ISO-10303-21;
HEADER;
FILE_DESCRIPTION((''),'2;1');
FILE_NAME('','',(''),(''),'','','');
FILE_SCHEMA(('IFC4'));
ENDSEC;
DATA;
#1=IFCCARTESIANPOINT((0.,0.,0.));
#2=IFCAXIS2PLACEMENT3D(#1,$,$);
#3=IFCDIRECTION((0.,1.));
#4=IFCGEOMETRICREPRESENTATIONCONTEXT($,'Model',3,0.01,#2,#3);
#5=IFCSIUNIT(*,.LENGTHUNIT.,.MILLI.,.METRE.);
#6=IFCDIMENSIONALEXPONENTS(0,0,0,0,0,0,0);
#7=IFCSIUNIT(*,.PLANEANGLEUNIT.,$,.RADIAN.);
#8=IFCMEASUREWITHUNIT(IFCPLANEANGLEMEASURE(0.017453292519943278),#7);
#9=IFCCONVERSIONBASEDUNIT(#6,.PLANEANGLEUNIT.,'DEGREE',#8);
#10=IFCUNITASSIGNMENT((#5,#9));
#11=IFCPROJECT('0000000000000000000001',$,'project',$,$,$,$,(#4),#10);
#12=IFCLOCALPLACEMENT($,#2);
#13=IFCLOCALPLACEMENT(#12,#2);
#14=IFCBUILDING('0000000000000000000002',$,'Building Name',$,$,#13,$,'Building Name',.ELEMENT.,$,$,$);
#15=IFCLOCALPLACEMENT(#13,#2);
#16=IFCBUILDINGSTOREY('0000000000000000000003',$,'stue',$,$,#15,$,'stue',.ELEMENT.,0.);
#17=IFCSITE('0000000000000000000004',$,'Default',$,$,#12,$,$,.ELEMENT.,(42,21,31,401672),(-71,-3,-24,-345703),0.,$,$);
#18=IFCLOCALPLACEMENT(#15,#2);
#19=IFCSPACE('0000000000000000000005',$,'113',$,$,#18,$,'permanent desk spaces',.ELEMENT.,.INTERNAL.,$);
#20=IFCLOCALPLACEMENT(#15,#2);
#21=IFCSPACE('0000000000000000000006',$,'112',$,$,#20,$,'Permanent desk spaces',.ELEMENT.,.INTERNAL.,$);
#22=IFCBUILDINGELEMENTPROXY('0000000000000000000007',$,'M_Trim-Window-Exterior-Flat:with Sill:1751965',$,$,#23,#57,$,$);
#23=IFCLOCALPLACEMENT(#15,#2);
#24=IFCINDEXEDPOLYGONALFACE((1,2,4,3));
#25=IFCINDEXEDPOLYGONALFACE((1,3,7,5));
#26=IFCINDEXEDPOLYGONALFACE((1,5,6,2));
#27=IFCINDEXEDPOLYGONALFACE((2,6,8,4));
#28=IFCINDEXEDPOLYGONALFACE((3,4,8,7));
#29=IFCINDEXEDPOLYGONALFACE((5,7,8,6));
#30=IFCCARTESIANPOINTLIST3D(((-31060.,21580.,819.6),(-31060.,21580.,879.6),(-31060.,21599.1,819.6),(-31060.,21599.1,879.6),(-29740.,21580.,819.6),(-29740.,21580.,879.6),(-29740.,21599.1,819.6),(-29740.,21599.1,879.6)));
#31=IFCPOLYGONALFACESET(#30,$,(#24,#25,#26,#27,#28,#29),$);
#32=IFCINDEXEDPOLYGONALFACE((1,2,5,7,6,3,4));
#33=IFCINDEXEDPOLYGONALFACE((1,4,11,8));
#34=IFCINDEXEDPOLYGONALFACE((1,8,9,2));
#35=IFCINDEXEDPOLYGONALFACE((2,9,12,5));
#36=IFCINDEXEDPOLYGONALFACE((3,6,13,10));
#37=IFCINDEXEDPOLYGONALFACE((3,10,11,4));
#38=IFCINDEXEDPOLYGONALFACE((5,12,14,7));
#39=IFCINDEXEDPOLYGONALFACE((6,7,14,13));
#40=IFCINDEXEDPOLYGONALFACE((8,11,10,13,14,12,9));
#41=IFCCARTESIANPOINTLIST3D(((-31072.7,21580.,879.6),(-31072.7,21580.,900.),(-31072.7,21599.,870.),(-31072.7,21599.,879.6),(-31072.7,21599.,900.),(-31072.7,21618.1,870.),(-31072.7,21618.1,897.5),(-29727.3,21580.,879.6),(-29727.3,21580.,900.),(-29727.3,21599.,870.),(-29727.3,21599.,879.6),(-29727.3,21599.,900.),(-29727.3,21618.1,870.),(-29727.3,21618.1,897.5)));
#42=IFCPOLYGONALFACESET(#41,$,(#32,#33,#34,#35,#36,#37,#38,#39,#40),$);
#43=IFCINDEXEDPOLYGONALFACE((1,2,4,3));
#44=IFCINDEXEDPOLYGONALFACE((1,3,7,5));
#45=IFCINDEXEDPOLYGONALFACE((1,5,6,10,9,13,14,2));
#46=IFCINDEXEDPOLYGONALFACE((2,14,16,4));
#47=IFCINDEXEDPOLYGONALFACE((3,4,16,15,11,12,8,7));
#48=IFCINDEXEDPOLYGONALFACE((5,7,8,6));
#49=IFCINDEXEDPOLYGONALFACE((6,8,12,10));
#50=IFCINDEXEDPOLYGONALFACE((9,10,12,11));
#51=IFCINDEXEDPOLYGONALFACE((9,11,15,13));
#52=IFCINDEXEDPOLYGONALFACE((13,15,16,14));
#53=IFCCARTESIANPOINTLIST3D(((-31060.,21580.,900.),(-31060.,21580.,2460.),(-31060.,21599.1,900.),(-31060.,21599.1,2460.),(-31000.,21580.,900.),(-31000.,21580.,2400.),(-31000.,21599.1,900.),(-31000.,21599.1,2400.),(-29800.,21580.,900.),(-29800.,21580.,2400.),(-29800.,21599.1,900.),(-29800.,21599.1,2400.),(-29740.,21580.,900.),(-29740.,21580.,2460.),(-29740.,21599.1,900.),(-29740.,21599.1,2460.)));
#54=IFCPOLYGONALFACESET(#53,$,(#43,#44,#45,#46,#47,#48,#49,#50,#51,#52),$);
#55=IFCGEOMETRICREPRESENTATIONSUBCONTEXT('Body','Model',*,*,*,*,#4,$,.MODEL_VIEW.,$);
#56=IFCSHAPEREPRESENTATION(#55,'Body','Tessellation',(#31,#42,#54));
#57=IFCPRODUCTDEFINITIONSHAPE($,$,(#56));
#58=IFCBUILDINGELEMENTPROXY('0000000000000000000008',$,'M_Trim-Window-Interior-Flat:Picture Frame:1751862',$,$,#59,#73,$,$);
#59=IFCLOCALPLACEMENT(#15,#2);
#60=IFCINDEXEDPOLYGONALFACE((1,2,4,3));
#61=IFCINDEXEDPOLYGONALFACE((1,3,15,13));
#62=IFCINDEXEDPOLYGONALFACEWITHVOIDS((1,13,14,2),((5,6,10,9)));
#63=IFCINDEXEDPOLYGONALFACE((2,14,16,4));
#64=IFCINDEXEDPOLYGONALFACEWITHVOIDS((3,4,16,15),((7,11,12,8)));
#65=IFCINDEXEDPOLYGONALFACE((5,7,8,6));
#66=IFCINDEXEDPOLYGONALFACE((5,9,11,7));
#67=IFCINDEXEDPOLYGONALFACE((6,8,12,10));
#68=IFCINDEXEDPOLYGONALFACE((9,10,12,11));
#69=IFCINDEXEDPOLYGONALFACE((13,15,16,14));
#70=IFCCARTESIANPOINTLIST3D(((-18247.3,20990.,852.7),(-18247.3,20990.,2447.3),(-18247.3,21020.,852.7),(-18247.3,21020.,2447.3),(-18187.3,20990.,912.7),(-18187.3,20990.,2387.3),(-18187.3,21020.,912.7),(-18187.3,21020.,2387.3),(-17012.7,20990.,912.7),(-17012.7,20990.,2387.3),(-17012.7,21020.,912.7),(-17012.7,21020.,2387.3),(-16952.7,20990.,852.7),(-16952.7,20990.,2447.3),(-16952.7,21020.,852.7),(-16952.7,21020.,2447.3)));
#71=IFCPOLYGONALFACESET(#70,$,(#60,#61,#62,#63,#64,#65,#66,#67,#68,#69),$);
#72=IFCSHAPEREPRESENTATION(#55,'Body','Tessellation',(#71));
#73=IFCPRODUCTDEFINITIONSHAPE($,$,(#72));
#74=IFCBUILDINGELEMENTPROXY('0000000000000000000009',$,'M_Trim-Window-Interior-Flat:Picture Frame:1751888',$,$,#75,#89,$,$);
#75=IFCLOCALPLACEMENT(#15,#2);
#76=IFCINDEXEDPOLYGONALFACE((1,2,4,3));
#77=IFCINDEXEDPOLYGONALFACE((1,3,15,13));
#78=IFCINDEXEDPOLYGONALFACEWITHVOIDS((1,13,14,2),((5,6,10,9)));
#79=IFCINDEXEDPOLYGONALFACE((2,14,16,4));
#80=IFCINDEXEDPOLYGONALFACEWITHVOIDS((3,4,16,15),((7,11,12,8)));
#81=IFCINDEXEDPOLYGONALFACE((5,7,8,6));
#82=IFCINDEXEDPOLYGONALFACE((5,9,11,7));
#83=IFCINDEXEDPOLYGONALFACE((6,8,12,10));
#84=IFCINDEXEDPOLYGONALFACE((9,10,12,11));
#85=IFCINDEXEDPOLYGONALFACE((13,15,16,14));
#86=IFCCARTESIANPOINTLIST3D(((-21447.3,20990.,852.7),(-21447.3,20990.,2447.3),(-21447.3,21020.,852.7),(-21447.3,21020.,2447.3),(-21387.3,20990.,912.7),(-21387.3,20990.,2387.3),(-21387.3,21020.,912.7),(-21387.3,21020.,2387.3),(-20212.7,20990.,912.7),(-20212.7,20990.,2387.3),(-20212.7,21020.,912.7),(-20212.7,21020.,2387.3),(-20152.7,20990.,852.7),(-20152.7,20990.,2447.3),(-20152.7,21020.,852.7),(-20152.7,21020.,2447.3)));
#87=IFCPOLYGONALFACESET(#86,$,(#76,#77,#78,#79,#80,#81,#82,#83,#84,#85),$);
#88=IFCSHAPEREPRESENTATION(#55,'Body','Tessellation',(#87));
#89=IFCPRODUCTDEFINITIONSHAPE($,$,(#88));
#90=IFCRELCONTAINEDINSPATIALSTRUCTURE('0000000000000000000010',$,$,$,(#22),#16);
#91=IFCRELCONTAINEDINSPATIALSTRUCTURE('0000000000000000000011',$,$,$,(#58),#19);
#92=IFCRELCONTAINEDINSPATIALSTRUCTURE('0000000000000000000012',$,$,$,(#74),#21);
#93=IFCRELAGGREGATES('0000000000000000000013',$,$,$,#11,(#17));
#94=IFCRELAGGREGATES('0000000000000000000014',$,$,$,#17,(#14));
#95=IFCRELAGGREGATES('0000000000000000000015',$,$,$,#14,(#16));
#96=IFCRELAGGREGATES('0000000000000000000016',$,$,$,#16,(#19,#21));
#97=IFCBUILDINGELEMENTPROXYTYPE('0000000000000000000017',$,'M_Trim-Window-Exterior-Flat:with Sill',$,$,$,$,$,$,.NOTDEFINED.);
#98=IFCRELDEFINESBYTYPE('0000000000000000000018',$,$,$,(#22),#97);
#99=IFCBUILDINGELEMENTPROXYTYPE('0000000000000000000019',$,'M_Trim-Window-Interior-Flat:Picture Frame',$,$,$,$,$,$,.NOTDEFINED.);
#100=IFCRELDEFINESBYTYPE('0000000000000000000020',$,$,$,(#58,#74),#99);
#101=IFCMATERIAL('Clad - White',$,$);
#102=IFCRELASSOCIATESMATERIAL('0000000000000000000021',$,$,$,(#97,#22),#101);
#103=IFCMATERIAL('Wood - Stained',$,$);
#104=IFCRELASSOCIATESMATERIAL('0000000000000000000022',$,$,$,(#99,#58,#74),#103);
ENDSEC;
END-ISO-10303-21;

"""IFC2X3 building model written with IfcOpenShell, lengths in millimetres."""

from ifc_helpers import new_model, entity, si_unit, converted_unit, direction, frame, frame_2d, origin, place, context, subcontext, project, spatial, polyline, rectangle, outline, extrude, source, transform, mapped, material, type_object, type_shapes, element, save


model = new_model("IFC2X3")

# Units and contexts
model_context = context("Model", 3, precision=0.01, world=origin(), true_north=direction((0.0, 1.0)))
body_context = subcontext(model_context, "Body", "Model", "MODEL_VIEW")
ifc_project = project(units=[si_unit("LENGTHUNIT", "METRE", prefix="MILLI"), converted_unit("PLANEANGLEUNIT", "DEGREE", entity("IfcPlaneAngleMeasure", 0.017453292519943278), si_unit("PLANEANGLEUNIT", "RADIAN"), dimensions=[0, 0, 0, 0, 0, 0, 0])], contexts=[model_context])

# Site, building, storey
site_placement = place(None, origin())
site = spatial("IfcSite", under=ifc_project, at=site_placement, Name="Default", CompositionType="ELEMENT", RefLatitude=(42, 21, 31, 401672), RefLongitude=(-71, -3, -24, -345703), RefElevation=0.0)
building_placement = place(site_placement, origin())
building = spatial("IfcBuilding", under=site, at=building_placement, Name="Building Name", LongName="Building Name", CompositionType="ELEMENT")
storey_placement = place(building_placement, origin())
storey = spatial("IfcBuildingStorey", under=building, at=storey_placement, Name="stue", LongName="stue", CompositionType="ELEMENT", Elevation=0.0)

# Building element proxy
ifc_material_1 = material(Name="Clad - White")
ifc_material_2 = material(Name="Wood - Stained")
building_element_proxy_type_1 = type_object("IfcBuildingElementProxyType", Name="M_Trim-Window-Exterior-Flat:with Sill", PredefinedType="NOTDEFINED", material=ifc_material_1)
shared_shape_1 = source(origin(), body_context, "Body", "SweptSolid", [
    extrude(rectangle(XDim=1320.0, YDim=60.0, at=frame_2d((0.0, 0.0), x_axis=(1.0, 0.0))), frame((0.0, -1550.4, 0.0), z_axis=(0.0, 0.0, 1.0), x_axis=(-1.0, 0.0, 0.0)), (0.0, 0.0, 1.0), 19.0),
    extrude(outline(polyline([(-19.0, -15.2), (0.0, -15.2), (0.0, -5.7), (19.0, -5.7), (19.0, 14.8), (0.0, 14.8), (-19.0, 12.3), (-19.0, -15.2)])), frame((-672.7, -1514.8, 19.0), z_axis=(1.0, 0.0, 0.0), x_axis=(0.0, 0.0, -1.0)), (0.0, 0.0, 1.0), 1345.4),
    extrude(outline(polyline([(-795.0, -660.0), (765.0, -660.0), (765.0, -600.0), (-735.0, -600.0), (-735.0, 600.0), (765.0, 600.0), (765.0, 660.0), (-795.0, 660.0), (-795.0, -660.0)])), frame((0.0, -735.0, 0.0), z_axis=(0.0, 0.0, 1.0), x_axis=(0.0, -1.0, 0.0)), (0.0, 0.0, 1.0), 19.0),
])
type_shapes(building_element_proxy_type_1, [shared_shape_1])
for number, where, z_axis, x_axis, name in (
    (1, (-30400.0, 21580.0, 2400.0), (0.0, 1.0, 0.0), (-1.0, 0.0, 0.0), "M_Trim-Window-Exterior-Flat:with Sill:1751965"),
):
    element("IfcBuildingElementProxy", number, at=place(storey_placement, frame(where, z_axis=z_axis, x_axis=x_axis)), inside=storey, type_object=building_element_proxy_type_1, material=ifc_material_1, Name=name, context=body_context, shape_type="MappedRepresentation", body=[
        mapped(shared_shape_1, transform((0.0, 0.0, 0.0), scale=1.0)),
    ])

# Shared definitions
space_1_placement = place(storey_placement, origin())
space_1 = spatial("IfcSpace", under=storey, at=space_1_placement, Name="113", LongName="permanent desk spaces", CompositionType="ELEMENT", InteriorOrExteriorSpace="INTERNAL")

# Building element proxy
building_element_proxy_type_2 = type_object("IfcBuildingElementProxyType", Name="M_Trim-Window-Interior-Flat:Picture Frame", PredefinedType="NOTDEFINED", material=ifc_material_2)
shared_shape_2 = source(origin(), body_context, "Body", "SweptSolid", [
    extrude(outline(polyline([(-647.3, -797.3), (647.3, -797.3), (647.3, 797.3), (-647.3, 797.3), (-647.3, -797.3)]), holes=[polyline([(-587.3, -737.3), (-587.3, 737.3), (587.3, 737.3), (587.3, -737.3), (-587.3, -737.3)])]), frame((0.0, -750.0, 0.0), z_axis=(0.0, 0.0, 1.0), x_axis=(-1.0, 0.0, 0.0)), (0.0, 0.0, 1.0), 30.0),
])
type_shapes(building_element_proxy_type_2, [shared_shape_2])
proxy_1_placement = place(space_1_placement, frame((-17600.0, 21020.0, 2400.0), z_axis=(0.0, -1.0, 0.0), x_axis=(1.0, 0.0, 0.0)))
element("IfcBuildingElementProxy", 2, at=proxy_1_placement, inside=space_1, type_object=building_element_proxy_type_2, material=ifc_material_2, Name="M_Trim-Window-Interior-Flat:Picture Frame:1751862", context=body_context, shape_type="MappedRepresentation", body=[
    mapped(shared_shape_2, transform((0.0, 0.0, 0.0), scale=1.0)),
])

# Shared definitions
space_2_placement = place(storey_placement, origin())
space_2 = spatial("IfcSpace", under=storey, at=space_2_placement, Name="112", LongName="Permanent desk spaces", CompositionType="ELEMENT", InteriorOrExteriorSpace="INTERNAL")

# Building element proxy
proxy_2_placement = place(space_2_placement, frame((-20800.0, 21020.0, 2400.0), z_axis=(0.0, -1.0, 0.0), x_axis=(1.0, 0.0, 0.0)))
element("IfcBuildingElementProxy", 3, at=proxy_2_placement, inside=space_2, type_object=building_element_proxy_type_2, material=ifc_material_2, Name="M_Trim-Window-Interior-Flat:Picture Frame:1751888", context=body_context, shape_type="MappedRepresentation", body=[
    mapped(shared_shape_2, transform((0.0, 0.0, 0.0), scale=1.0)),
])

save(model, "model.ifc")
